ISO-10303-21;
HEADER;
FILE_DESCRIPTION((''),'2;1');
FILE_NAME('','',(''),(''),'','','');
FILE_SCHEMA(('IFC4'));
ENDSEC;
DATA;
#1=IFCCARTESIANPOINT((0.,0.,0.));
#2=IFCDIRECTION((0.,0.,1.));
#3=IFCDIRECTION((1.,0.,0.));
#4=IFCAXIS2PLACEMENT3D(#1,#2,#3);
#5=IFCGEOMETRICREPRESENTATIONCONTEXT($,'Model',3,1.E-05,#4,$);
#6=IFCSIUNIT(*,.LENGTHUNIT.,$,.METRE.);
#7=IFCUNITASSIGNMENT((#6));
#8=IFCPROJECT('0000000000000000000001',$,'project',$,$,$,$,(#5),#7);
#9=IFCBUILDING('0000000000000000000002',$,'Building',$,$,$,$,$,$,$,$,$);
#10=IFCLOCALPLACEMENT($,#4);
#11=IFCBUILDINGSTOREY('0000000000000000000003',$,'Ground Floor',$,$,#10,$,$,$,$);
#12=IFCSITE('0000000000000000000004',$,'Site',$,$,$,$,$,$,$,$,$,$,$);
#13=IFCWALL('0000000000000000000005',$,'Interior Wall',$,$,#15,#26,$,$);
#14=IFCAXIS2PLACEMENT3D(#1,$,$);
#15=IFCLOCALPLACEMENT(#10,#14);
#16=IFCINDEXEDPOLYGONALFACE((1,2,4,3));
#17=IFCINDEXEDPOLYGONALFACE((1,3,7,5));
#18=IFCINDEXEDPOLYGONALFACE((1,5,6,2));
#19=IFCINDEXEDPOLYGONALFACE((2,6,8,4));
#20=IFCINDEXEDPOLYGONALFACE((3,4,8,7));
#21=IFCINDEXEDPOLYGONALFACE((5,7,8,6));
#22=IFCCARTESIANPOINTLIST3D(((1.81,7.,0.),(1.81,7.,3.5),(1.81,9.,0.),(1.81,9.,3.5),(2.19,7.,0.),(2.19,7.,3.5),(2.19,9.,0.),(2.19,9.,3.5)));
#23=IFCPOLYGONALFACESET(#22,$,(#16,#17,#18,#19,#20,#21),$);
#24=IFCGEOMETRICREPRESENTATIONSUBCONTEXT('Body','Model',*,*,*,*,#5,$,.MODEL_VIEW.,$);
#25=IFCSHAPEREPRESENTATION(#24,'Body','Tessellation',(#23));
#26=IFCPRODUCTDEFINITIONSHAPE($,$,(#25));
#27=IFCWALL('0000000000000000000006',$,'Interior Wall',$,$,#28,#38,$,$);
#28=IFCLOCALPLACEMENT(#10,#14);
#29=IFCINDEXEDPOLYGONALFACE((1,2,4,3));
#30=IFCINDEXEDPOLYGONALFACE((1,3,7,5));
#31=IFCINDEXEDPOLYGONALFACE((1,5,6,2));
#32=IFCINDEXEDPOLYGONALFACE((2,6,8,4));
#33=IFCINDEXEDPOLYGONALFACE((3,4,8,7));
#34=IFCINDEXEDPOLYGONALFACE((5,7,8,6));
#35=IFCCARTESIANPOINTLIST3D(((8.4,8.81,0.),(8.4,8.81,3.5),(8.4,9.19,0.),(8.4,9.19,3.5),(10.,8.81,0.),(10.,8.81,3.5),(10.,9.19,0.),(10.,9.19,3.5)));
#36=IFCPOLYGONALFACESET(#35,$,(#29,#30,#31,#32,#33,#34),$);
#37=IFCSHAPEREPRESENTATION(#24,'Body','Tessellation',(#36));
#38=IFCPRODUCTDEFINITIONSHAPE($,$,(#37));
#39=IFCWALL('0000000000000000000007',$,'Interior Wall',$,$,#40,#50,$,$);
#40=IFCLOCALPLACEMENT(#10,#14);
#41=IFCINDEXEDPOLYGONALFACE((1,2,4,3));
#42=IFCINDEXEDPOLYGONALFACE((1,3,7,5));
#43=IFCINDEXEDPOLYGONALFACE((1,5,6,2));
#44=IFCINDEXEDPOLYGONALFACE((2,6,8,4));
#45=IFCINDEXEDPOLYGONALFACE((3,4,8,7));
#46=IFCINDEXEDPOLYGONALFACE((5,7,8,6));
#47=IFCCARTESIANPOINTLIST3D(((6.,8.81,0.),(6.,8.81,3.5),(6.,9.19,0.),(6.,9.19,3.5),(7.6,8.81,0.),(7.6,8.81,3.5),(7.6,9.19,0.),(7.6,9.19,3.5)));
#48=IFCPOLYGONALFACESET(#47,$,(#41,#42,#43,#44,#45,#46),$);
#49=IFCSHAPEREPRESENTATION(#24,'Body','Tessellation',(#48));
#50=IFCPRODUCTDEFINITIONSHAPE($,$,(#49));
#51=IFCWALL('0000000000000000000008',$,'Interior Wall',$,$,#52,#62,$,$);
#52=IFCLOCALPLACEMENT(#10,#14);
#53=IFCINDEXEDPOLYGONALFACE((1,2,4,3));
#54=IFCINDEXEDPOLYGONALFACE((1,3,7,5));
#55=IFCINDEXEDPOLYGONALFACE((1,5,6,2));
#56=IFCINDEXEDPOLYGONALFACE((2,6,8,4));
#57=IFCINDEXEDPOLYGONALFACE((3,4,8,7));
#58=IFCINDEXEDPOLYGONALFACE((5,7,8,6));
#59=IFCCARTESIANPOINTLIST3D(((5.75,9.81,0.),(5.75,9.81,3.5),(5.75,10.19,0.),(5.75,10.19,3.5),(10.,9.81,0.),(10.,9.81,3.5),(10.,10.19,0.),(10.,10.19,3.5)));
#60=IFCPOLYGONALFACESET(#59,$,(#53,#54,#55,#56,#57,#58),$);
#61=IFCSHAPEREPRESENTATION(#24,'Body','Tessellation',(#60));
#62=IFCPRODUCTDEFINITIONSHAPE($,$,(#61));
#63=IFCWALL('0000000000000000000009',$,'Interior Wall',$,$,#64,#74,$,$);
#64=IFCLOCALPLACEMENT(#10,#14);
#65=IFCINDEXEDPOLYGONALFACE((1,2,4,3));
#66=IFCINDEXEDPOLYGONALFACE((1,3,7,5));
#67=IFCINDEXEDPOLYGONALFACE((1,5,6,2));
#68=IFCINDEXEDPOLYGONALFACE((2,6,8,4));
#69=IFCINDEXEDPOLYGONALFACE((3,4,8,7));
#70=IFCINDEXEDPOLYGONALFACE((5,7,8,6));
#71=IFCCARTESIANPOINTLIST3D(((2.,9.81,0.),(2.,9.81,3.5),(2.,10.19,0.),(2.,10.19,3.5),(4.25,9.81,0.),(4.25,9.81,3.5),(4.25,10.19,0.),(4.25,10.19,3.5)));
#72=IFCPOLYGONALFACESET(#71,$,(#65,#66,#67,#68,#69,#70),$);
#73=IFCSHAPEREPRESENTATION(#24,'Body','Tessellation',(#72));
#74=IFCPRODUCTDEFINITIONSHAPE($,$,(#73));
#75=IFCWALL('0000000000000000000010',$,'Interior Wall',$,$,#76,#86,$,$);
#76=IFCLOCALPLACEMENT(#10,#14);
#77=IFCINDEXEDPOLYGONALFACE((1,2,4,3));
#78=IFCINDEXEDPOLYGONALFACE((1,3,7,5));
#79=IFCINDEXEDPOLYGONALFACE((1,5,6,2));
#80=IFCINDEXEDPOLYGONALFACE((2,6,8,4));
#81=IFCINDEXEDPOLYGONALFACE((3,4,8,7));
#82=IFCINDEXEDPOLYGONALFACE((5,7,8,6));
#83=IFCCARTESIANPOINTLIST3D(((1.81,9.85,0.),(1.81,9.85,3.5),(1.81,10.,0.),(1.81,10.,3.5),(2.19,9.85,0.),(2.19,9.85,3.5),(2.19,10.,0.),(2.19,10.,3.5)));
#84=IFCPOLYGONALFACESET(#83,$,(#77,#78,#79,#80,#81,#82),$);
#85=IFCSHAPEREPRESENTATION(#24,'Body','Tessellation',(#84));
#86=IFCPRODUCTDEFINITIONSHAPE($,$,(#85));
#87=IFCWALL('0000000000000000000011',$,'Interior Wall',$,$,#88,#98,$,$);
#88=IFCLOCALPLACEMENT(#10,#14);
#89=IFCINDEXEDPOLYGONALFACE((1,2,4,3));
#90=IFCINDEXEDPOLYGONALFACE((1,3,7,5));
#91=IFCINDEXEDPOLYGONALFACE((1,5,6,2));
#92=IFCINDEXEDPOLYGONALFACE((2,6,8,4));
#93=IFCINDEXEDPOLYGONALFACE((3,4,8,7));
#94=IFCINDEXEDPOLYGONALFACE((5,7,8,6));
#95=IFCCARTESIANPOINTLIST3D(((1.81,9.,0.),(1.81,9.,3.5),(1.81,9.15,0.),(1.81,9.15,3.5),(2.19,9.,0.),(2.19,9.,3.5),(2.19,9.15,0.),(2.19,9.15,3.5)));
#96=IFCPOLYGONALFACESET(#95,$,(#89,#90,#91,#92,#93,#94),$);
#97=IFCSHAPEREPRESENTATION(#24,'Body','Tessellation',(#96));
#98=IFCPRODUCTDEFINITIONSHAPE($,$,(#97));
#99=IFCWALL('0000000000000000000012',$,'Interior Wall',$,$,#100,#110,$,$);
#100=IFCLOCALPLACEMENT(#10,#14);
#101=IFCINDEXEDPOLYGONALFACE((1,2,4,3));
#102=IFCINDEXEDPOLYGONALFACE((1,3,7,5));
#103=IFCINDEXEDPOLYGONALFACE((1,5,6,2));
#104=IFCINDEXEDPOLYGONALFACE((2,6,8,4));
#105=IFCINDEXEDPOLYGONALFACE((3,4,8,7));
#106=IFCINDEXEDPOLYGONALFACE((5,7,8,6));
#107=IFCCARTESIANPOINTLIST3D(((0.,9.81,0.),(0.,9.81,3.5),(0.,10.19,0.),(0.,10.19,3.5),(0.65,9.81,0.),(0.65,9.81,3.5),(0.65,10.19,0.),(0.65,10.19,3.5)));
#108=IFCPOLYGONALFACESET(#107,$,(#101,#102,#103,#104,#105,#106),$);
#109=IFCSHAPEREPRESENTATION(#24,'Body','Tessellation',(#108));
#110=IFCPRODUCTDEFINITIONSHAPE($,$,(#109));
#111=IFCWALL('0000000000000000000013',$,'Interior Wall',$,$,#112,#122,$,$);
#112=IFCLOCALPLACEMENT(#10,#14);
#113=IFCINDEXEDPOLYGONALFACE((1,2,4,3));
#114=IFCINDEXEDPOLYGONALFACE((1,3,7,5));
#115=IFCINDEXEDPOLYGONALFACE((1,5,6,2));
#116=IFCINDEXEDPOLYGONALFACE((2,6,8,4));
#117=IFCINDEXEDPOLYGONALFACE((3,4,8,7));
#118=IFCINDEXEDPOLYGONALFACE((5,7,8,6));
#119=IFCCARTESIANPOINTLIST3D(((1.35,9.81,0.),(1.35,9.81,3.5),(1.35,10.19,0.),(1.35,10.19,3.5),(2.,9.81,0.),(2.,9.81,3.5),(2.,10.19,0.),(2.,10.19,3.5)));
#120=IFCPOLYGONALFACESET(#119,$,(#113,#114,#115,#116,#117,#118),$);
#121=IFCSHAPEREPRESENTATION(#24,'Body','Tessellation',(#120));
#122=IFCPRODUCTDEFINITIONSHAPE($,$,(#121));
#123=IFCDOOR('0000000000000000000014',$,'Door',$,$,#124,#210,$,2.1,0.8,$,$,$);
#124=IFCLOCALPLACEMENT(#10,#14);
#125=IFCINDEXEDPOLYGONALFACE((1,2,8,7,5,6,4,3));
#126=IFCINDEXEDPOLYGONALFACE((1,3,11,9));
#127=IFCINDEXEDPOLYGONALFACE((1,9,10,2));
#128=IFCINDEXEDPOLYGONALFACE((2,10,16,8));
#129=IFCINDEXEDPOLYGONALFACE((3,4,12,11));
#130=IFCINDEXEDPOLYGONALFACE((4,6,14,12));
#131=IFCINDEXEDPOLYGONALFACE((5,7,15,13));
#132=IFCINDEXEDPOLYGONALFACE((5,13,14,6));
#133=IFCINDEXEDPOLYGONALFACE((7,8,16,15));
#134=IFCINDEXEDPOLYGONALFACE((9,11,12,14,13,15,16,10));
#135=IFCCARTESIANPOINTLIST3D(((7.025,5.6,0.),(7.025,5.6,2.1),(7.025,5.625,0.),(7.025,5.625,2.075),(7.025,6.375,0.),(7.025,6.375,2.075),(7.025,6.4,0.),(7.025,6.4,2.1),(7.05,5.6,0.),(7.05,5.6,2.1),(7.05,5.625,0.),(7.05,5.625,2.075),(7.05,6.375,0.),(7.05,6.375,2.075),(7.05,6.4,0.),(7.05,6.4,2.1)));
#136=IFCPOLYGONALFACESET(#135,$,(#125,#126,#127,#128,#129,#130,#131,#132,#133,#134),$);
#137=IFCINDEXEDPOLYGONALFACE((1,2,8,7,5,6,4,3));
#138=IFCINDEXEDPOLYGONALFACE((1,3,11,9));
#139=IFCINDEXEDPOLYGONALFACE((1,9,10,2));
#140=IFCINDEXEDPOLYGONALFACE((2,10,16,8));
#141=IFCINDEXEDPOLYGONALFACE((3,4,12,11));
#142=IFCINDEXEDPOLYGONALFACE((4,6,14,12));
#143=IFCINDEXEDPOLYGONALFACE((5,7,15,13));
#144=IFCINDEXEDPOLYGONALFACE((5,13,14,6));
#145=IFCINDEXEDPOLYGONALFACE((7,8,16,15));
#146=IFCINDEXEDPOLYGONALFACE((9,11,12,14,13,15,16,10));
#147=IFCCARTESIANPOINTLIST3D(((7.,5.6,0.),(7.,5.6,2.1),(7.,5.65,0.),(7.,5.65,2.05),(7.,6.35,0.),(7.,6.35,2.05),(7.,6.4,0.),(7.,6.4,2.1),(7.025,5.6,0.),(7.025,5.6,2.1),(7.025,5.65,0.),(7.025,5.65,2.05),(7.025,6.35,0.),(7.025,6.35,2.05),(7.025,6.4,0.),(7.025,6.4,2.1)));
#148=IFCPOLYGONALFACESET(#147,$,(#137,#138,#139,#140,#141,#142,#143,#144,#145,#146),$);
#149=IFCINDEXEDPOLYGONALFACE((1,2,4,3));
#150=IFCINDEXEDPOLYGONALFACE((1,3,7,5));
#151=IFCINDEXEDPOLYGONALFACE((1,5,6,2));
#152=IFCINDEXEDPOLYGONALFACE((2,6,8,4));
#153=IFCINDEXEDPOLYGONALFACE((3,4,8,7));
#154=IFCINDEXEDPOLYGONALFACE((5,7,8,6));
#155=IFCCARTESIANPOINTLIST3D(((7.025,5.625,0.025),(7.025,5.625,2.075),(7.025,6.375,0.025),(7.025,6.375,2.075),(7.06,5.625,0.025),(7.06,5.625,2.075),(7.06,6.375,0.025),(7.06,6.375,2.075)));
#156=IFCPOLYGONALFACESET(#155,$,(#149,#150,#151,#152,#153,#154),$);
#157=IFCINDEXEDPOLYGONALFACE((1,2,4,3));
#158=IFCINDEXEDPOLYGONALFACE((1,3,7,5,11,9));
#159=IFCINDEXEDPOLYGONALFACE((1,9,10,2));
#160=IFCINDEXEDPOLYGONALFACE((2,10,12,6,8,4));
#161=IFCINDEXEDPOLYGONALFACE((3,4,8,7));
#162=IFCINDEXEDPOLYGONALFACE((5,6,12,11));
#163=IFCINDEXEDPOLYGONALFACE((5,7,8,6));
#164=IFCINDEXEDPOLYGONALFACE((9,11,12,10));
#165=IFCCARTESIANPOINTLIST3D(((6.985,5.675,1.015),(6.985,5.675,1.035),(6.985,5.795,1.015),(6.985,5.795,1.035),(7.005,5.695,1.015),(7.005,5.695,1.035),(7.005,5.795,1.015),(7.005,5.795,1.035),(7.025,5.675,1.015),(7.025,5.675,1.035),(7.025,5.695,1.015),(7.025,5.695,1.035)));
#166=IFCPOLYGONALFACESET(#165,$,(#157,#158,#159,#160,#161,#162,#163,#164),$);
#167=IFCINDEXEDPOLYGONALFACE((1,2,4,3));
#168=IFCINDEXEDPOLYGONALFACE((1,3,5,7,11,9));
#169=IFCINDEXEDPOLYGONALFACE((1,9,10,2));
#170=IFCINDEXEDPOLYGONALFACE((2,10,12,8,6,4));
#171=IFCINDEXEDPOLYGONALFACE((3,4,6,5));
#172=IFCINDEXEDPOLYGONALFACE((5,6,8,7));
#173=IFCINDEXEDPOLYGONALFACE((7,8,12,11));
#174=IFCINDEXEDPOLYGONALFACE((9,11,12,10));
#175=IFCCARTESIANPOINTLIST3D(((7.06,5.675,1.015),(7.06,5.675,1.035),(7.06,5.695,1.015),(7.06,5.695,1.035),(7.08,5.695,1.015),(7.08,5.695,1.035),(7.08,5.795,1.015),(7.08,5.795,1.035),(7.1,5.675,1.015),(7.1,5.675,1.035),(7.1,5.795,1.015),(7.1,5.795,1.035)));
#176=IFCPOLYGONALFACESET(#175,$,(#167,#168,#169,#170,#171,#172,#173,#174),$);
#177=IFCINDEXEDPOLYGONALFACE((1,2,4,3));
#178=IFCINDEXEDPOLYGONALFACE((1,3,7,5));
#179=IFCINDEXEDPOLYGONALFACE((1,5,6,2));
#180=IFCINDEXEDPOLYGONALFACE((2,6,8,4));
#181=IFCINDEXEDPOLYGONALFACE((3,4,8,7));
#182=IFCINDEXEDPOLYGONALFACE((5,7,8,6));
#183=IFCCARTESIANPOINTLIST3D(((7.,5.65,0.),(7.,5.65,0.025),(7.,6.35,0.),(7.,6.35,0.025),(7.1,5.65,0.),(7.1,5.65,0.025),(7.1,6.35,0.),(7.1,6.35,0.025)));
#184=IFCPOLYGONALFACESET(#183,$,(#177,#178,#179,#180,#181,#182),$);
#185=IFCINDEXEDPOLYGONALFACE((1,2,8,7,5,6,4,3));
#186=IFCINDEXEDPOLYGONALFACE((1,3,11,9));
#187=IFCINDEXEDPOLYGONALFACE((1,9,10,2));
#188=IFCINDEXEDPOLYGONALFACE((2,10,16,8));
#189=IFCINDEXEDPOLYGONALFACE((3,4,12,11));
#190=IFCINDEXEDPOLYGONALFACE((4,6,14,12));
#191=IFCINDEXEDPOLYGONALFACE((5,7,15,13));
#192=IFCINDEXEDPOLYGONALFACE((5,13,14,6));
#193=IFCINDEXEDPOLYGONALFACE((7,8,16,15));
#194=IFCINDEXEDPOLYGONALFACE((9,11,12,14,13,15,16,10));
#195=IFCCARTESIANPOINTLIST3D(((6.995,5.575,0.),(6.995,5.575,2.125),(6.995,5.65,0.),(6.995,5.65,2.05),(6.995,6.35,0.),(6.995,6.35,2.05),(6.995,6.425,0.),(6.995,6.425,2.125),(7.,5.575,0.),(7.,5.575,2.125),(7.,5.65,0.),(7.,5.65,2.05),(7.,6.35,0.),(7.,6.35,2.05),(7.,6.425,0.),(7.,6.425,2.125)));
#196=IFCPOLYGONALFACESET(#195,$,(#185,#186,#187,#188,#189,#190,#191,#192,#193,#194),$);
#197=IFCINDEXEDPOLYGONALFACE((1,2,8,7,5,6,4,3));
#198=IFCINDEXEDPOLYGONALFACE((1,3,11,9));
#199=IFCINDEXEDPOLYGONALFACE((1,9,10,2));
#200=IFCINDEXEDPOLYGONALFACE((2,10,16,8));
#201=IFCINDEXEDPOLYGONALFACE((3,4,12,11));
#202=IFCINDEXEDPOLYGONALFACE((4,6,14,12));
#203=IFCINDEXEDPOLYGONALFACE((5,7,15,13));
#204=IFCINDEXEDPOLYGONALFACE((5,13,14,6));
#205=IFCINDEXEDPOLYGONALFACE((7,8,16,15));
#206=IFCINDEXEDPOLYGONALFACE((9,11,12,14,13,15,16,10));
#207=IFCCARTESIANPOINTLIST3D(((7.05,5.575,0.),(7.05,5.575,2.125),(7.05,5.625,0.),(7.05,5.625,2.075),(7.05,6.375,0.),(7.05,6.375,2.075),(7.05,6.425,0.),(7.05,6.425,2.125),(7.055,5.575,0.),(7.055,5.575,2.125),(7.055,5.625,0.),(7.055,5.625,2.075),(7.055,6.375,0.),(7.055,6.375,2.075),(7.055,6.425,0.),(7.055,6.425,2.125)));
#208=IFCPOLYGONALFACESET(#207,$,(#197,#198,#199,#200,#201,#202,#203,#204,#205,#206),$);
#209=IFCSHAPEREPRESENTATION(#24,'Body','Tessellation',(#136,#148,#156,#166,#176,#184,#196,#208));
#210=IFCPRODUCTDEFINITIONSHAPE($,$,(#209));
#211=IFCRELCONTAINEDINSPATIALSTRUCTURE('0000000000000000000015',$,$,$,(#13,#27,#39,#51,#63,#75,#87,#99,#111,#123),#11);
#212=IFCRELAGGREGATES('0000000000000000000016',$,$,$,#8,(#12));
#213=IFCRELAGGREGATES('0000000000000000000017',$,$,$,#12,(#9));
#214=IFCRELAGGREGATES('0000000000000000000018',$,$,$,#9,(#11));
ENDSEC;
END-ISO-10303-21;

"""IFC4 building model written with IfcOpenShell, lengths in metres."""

from ifc_helpers import new_model, si_unit, frame, origin_with_axes, place, context, subcontext, project, spatial, line, indexed_curve, outline, extrude, element, save


model = new_model("IFC4")

# Units and contexts
model_context = context("Model", 3, precision=1e-05, world=origin_with_axes())
body_context = subcontext(model_context, "Body", "Model", "MODEL_VIEW")
ifc_project = project(units=[si_unit("LENGTHUNIT", "METRE")], contexts=[model_context])

# Site, building, storey
site = spatial("IfcSite", under=ifc_project, Name="Site")
building = spatial("IfcBuilding", under=site, Name="Building")
storey_placement = place(None, origin_with_axes())
storey = spatial("IfcBuildingStorey", under=building, at=storey_placement, Name="Ground Floor")

# Walls
wall_1_placement = place(storey_placement, frame((2.0, 9.0, 0.0), z_axis=(0.0, 0.0, 1.0), x_axis=(0.0, -1.0, 0.0)))
element("IfcWall", 1, at=wall_1_placement, inside=storey, Name="Interior Wall", context=body_context, shape_type="SweptSolid", body=[
    extrude(outline(indexed_curve([(0.0, 0.0), (0.0, 0.38), (2.0, 0.38), (2.0, 0.0), (0.0, 0.0)], self_intersect=False)), frame((0.0, -0.19, 0.0), z_axis=(0.0, 0.0, 1.0), x_axis=(1.0, 0.0, 0.0)), (0.0, 0.0, 1.0), 3.5),
])
for number, where, z_axis, x_axis, name in (
    (2, (10.0, 9.0, 0.0), (0.0, 0.0, 1.0), (-1.0, 0.0, 0.0), "Interior Wall"),
    (3, (7.6, 9.0, 0.0), (0.0, 0.0, 1.0), (-1.0, 0.0, 0.0), "Interior Wall"),
):
    element("IfcWall", number, at=place(storey_placement, frame(where, z_axis=z_axis, x_axis=x_axis)), inside=storey, Name=name, context=body_context, shape_type="SweptSolid", body=[
        extrude(outline(indexed_curve([(0.0, 0.0), (0.0, 0.38), (1.6, 0.38), (1.6, 0.0), (0.0, 0.0)], self_intersect=False)), frame((0.0, -0.19, 0.0), z_axis=(0.0, 0.0, 1.0), x_axis=(1.0, 0.0, 0.0)), (0.0, 0.0, 1.0), 3.5),
    ])
wall_2_placement = place(storey_placement, frame((10.0, 10.0, 0.0), z_axis=(0.0, 0.0, 1.0), x_axis=(-1.0, 0.0, 0.0)))
element("IfcWall", 4, at=wall_2_placement, inside=storey, Name="Interior Wall", context=body_context, shape_type="SweptSolid", body=[
    extrude(outline(indexed_curve([(0.0, 0.0), (0.0, 0.38), (4.25, 0.38), (4.25, 0.0), (0.0, 0.0)], self_intersect=False)), frame((0.0, -0.19, 0.0), z_axis=(0.0, 0.0, 1.0), x_axis=(1.0, 0.0, 0.0)), (0.0, 0.0, 1.0), 3.5),
])
wall_3_placement = place(storey_placement, frame((4.25, 10.0, 0.0), z_axis=(0.0, 0.0, 1.0), x_axis=(-1.0, 0.0, 0.0)))
element("IfcWall", 5, at=wall_3_placement, inside=storey, Name="Interior Wall", context=body_context, shape_type="SweptSolid", body=[
    extrude(outline(indexed_curve([(0.0, 0.0), (0.0, 0.38), (2.25, 0.38), (2.25, 0.0), (0.0, 0.0)], self_intersect=False)), frame((0.0, -0.19, 0.0), z_axis=(0.0, 0.0, 1.0), x_axis=(1.0, 0.0, 0.0)), (0.0, 0.0, 1.0), 3.5),
])
for number, where, z_axis, x_axis, name in (
    (6, (2.0, 10.0, 0.0), (0.0, 0.0, 1.0), (0.0, -1.0, 0.0), "Interior Wall"),
    (7, (2.0, 9.15, 0.0), (0.0, 0.0, 1.0), (0.0, -1.0, 0.0), "Interior Wall"),
):
    element("IfcWall", number, at=place(storey_placement, frame(where, z_axis=z_axis, x_axis=x_axis)), inside=storey, Name=name, context=body_context, shape_type="SweptSolid", body=[
        extrude(outline(indexed_curve([(0.0, 0.0), (0.0, 0.38), (0.15, 0.38), (0.15, 0.0), (0.0, 0.0)], self_intersect=False)), frame((0.0, -0.19, 0.0), z_axis=(0.0, 0.0, 1.0), x_axis=(1.0, 0.0, 0.0)), (0.0, 0.0, 1.0), 3.5),
    ])
wall_4_placement = place(storey_placement, frame((0.0, 10.0, 0.0), z_axis=(0.0, 0.0, 1.0), x_axis=(1.0, 0.0, 0.0)))
element("IfcWall", 8, at=wall_4_placement, inside=storey, Name="Interior Wall", context=body_context, shape_type="SweptSolid", body=[
    extrude(outline(indexed_curve([(0.0, 0.0), (0.0, 0.38), (0.65, 0.38), (0.65, 0.0), (0.0, 0.0)], self_intersect=False)), frame((0.0, -0.19, 0.0), z_axis=(0.0, 0.0, 1.0), x_axis=(1.0, 0.0, 0.0)), (0.0, 0.0, 1.0), 3.5),
])
wall_5_placement = place(storey_placement, frame((1.35, 10.0, 0.0), z_axis=(0.0, 0.0, 1.0), x_axis=(1.0, 0.0, 0.0)))
element("IfcWall", 9, at=wall_5_placement, inside=storey, Name="Interior Wall", context=body_context, shape_type="SweptSolid", body=[
    extrude(outline(indexed_curve([(0.0, 0.0), (0.0, 0.38), (0.65, 0.38), (0.65, 0.0), (0.0, 0.0)], self_intersect=False)), frame((0.0, -0.19, 0.0), z_axis=(0.0, 0.0, 1.0), x_axis=(1.0, 0.0, 0.0)), (0.0, 0.0, 1.0), 3.5),
])

# Door
door_1_placement = place(storey_placement, frame((7.0, 6.4, 0.0), z_axis=(0.0, 0.0, 1.0), x_axis=(0.0, -1.0, 0.0)))
element("IfcDoor", 10, at=door_1_placement, inside=storey, Name="Door", OverallHeight=2.1, OverallWidth=0.8, context=body_context, shape_type="SweptSolid", body=[
    extrude(outline(indexed_curve([(0.0, 0.0), (0.0, 2.1), (0.8, 2.1), (0.8, 0.0), (0.775, 0.0), (0.775, 2.075), (0.025, 2.075), (0.025, 0.0)], segments=[line(1, 2, 3, 4, 5, 6, 7, 8, 1)])), frame((0.0, 0.025, 0.0), z_axis=(0.0, -1.0, 0.0), x_axis=(1.0, 0.0, 0.0)), (0.0, 0.0, -1.0), 0.025),
    extrude(outline(indexed_curve([(0.0, 0.0), (0.0, 2.1), (0.8, 2.1), (0.8, 0.0), (0.75, 0.0), (0.75, 2.05), (0.05, 2.05), (0.05, 0.0)], segments=[line(1, 2, 3, 4, 5, 6, 7, 8, 1)])), frame((0.0, 0.0, 0.0), z_axis=(0.0, -1.0, 0.0), x_axis=(1.0, 0.0, 0.0)), (0.0, 0.0, -1.0), 0.025),
    extrude(outline(indexed_curve([(0.0, 0.0), (0.75, 0.0), (0.75, 0.035), (0.0, 0.035)], segments=[line(1, 2, 3, 4, 1)])), frame((0.025, 0.025, 0.025), z_axis=(0.0, 0.0, 1.0), x_axis=(1.0, 0.0, 0.0)), (0.0, 0.0, 1.0), 2.05),
    extrude(outline(indexed_curve([(0.0, 0.0), (0.0, -0.04), (-0.12, -0.04), (-0.12, -0.02), (-0.02, -0.02), (-0.02, 0.0)], segments=[line(1, 2, 3, 4, 5, 6, 1)])), frame((0.725, 0.025, 1.015), z_axis=(0.0, 0.0, 1.0), x_axis=(1.0, 0.0, 0.0)), (0.0, 0.0, 1.0), 0.02),
    extrude(outline(indexed_curve([(0.0, 0.0), (0.0, 0.04), (-0.12, 0.04), (-0.12, 0.02), (-0.02, 0.02), (-0.02, 0.0)], segments=[line(1, 2, 3, 4, 5, 6, 1)])), frame((0.725, 0.06, 1.015), z_axis=(0.0, 0.0, 1.0), x_axis=(1.0, 0.0, 0.0)), (0.0, 0.0, 1.0), 0.02),
    extrude(outline(indexed_curve([(0.0, 0.0), (0.7, 0.0), (0.7, 0.1), (0.0, 0.1)], segments=[line(1, 2, 3, 4, 1)])), frame((0.05, 0.0, 0.0), z_axis=(0.0, 0.0, 1.0), x_axis=(1.0, 0.0, 0.0)), (0.0, 0.0, 1.0), 0.025),
    extrude(outline(indexed_curve([(0.0, 0.0), (0.0, 2.125), (0.85, 2.125), (0.85, 0.0), (0.775, 0.0), (0.775, 2.05), (0.075, 2.05), (0.075, 0.0)], segments=[line(1, 2, 3, 4, 5, 6, 7, 8, 1)])), frame((-0.025, -0.005, 0.0), z_axis=(0.0, -1.0, 0.0), x_axis=(1.0, 0.0, 0.0)), (0.0, 0.0, -1.0), 0.005),
    extrude(outline(indexed_curve([(0.0, 0.0), (0.0, 2.125), (0.85, 2.125), (0.85, 0.0), (0.8, 0.0), (0.8, 2.075), (0.05, 2.075), (0.05, 0.0)], segments=[line(1, 2, 3, 4, 5, 6, 7, 8, 1)])), frame((-0.025, 0.05, 0.0), z_axis=(0.0, -1.0, 0.0), x_axis=(1.0, 0.0, 0.0)), (0.0, 0.0, -1.0), 0.005),
])

save(model, "model.ifc")
